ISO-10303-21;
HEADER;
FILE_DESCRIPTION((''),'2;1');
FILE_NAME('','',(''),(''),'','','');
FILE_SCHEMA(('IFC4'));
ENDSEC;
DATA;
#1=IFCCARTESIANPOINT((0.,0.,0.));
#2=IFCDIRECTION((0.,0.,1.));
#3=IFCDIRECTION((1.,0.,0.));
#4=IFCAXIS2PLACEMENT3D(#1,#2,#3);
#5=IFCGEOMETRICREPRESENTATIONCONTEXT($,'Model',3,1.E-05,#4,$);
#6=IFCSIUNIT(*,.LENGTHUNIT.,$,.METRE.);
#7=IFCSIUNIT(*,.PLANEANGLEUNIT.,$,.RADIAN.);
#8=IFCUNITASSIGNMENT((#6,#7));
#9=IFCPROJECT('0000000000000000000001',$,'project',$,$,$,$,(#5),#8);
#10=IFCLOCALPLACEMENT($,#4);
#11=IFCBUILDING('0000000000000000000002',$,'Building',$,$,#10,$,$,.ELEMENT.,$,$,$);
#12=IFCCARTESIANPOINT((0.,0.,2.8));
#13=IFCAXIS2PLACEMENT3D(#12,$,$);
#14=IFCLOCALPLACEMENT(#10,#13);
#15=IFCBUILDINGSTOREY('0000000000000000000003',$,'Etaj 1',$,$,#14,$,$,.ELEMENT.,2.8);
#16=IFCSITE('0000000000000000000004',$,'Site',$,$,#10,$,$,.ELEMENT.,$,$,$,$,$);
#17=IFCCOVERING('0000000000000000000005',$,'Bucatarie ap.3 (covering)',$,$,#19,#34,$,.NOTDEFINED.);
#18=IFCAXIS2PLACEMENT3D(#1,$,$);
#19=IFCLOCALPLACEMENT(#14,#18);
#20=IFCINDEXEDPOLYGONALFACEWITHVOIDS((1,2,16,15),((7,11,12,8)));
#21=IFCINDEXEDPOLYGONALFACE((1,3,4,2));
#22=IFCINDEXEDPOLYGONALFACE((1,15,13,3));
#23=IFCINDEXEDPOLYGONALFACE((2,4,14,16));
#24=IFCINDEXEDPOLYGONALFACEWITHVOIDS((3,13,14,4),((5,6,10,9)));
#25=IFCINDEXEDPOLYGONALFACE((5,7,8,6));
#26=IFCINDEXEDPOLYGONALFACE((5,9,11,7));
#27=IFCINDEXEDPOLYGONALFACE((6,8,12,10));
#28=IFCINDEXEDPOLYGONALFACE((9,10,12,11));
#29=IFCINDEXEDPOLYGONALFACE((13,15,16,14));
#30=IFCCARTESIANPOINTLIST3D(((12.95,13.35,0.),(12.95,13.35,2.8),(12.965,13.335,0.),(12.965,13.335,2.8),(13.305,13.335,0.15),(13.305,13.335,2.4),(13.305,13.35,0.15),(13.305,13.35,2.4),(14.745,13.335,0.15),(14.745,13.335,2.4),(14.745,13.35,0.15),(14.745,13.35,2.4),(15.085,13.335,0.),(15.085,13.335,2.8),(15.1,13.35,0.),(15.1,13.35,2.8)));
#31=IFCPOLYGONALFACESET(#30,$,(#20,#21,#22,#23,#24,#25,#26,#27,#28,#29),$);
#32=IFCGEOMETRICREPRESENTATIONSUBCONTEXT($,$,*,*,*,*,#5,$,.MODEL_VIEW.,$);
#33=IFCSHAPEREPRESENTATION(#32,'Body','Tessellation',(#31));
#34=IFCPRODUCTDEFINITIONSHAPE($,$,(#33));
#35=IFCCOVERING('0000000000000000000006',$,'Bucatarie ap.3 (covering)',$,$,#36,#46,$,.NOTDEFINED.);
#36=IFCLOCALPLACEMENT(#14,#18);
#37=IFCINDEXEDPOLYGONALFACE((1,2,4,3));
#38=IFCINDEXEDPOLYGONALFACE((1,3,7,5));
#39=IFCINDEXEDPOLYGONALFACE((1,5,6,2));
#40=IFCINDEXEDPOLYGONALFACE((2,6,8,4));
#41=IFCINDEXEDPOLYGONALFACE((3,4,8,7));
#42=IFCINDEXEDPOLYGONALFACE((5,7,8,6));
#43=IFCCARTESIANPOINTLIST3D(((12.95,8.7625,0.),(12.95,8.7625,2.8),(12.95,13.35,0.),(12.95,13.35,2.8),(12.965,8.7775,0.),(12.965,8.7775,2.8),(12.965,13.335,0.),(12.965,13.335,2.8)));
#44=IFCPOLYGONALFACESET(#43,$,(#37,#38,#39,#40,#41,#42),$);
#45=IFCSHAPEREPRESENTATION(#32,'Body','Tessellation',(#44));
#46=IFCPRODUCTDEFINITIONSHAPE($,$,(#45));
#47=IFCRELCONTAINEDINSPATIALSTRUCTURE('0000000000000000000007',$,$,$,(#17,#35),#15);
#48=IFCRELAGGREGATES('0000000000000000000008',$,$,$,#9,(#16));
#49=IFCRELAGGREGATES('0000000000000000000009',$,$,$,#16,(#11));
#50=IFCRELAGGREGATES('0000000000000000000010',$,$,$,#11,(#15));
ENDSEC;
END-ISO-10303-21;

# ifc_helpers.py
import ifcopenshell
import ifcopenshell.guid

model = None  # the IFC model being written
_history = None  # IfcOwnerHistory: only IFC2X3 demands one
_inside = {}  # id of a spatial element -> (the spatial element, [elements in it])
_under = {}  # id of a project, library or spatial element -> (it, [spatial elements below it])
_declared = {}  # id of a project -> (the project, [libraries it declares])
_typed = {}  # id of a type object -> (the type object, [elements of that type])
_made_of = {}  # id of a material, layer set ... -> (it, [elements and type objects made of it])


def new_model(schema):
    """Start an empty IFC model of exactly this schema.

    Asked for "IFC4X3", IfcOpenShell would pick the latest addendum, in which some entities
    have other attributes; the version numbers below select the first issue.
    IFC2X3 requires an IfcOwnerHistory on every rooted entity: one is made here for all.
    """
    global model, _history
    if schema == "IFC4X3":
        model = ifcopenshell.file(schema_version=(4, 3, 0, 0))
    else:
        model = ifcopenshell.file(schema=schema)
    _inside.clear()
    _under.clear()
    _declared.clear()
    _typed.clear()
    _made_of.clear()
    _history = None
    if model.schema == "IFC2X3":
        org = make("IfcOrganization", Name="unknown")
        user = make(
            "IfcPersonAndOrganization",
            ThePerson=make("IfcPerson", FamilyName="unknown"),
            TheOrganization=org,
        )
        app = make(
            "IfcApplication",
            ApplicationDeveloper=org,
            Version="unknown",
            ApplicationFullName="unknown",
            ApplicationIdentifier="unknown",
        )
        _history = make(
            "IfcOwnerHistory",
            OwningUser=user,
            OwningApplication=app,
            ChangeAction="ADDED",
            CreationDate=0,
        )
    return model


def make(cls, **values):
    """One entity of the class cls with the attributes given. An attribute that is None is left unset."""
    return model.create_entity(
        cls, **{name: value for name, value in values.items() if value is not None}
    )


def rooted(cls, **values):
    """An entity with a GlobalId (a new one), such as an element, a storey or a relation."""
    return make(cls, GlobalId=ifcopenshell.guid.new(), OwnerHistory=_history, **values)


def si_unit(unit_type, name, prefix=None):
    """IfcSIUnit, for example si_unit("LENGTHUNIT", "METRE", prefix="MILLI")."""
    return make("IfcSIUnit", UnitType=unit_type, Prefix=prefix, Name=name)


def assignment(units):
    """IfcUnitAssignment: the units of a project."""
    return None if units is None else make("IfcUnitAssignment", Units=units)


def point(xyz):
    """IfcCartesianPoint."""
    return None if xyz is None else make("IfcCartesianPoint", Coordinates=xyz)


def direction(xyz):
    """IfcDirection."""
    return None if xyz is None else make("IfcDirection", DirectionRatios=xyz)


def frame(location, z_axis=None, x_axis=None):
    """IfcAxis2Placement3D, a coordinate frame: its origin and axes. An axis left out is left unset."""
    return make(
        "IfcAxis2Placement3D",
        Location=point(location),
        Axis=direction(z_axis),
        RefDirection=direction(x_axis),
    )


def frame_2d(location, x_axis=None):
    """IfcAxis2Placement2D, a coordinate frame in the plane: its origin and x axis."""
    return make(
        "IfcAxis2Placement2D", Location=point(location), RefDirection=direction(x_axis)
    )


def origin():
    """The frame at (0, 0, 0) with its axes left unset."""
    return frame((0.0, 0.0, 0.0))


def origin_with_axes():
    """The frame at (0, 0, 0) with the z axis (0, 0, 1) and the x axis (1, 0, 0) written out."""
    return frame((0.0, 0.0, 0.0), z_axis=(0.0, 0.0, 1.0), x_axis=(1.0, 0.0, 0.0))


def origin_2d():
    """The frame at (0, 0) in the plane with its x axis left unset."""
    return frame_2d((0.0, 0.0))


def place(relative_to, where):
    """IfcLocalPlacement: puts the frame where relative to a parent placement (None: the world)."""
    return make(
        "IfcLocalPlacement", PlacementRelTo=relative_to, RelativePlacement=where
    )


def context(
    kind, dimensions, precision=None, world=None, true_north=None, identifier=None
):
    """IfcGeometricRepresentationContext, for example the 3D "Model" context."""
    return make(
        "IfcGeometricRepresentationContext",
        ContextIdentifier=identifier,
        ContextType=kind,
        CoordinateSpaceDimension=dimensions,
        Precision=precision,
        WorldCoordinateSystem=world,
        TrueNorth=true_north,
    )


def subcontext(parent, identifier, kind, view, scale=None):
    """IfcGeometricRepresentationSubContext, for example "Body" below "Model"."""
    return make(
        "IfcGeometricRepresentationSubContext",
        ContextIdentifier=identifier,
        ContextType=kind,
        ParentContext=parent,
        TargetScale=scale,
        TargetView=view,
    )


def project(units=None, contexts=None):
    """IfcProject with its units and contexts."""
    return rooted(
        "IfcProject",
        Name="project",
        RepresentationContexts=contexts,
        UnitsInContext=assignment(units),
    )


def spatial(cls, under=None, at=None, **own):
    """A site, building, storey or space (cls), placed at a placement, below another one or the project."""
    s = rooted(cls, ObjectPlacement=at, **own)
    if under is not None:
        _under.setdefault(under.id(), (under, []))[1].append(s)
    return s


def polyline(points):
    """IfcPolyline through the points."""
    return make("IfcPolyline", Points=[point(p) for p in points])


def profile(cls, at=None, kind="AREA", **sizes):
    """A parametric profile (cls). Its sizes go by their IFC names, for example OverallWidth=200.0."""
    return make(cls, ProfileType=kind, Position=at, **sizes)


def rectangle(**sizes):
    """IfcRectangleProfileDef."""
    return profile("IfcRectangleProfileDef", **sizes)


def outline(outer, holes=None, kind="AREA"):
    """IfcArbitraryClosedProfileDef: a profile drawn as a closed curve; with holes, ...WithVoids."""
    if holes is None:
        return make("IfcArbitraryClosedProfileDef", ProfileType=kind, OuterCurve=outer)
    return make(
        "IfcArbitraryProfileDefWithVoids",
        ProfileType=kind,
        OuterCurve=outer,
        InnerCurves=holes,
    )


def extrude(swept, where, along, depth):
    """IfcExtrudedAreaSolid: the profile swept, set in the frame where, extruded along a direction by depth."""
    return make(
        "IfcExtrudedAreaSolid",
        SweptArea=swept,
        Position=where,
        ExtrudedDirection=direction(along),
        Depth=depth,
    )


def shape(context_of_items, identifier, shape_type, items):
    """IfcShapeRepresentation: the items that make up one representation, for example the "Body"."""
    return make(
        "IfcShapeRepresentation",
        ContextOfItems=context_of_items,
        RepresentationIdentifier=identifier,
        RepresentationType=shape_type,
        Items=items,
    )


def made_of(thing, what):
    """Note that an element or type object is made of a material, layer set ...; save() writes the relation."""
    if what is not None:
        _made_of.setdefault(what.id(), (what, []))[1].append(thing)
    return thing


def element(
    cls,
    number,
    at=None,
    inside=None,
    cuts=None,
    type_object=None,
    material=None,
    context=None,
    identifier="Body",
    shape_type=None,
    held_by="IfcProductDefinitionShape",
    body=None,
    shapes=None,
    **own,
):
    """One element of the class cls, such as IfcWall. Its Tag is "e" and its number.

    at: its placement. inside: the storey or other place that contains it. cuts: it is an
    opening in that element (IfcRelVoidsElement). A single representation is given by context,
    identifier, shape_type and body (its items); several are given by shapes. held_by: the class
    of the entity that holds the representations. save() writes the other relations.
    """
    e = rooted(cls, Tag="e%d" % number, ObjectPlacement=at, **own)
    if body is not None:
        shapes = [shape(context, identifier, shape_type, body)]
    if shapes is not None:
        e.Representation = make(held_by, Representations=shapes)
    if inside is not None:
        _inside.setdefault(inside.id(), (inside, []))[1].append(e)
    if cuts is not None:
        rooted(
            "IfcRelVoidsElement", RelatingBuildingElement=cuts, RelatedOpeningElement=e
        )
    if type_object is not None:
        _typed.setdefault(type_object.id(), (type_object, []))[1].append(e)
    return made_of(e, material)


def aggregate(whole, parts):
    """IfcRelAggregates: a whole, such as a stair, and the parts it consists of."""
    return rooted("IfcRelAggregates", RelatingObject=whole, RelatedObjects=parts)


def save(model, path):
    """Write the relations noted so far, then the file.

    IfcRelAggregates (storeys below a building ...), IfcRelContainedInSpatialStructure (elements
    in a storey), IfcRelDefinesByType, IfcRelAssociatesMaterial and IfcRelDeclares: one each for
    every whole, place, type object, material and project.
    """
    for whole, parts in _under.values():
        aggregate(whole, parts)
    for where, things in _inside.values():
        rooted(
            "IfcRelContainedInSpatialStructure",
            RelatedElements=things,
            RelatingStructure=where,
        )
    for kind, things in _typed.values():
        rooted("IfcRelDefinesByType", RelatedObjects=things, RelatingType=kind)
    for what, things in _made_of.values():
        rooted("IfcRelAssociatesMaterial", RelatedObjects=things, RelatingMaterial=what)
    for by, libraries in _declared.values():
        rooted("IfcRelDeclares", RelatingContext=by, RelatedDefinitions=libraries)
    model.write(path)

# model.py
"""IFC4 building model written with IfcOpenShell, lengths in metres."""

from ifc_helpers import new_model, si_unit, frame, origin, origin_with_axes, origin_2d, place, context, subcontext, project, spatial, polyline, rectangle, outline, extrude, element, save


model = new_model("IFC4")

# Units and contexts
model_context = context("Model", 3, precision=1e-05, world=origin_with_axes())
sub_context = subcontext(model_context, None, None, "MODEL_VIEW")
ifc_project = project(units=[si_unit("LENGTHUNIT", "METRE"), si_unit("PLANEANGLEUNIT", "RADIAN")], contexts=[model_context])

# Site, building, storey
placement = place(None, origin_with_axes())
site = spatial("IfcSite", under=ifc_project, at=placement, Name="Site", CompositionType="ELEMENT")
building = spatial("IfcBuilding", under=site, at=placement, Name="Building", CompositionType="ELEMENT")
storey_placement = place(placement, frame((0.0, 0.0, 2.8)))
storey = spatial("IfcBuildingStorey", under=building, at=storey_placement, Name="Etaj 1", CompositionType="ELEMENT", Elevation=2.8)

# Covering, opening
covering_1_placement = place(storey_placement, origin_with_axes())
covering_1 = element("IfcCovering", 1, at=covering_1_placement, inside=storey, Name="Bucatarie ap.3 (covering)", PredefinedType="NOTDEFINED", context=sub_context, shape_type="SweptSolid", body=[
    extrude(outline(polyline([(15.1, 13.35), (12.95, 13.35), (12.965, 13.335), (15.085, 13.335), (15.1, 13.35)])), origin(), (0.0, 0.0, 1.0), 2.8),
])
opening_1_placement = place(covering_1_placement, frame((14.025, 13.665, 0.15), z_axis=(0.0, -1.0, 0.0), x_axis=(1.0, 0.0, 0.0)))
element("IfcOpeningElement", 2, at=opening_1_placement, cuts=covering_1, PredefinedType="OPENING", context=sub_context, shape_type="SweptSolid", body=[
    extrude(rectangle(XDim=1.44, YDim=2.25, at=origin_2d()), frame((0.0, 1.125, 0.0)), (0.0, 0.0, 1.0), 0.38),
])

# Covering
covering_2_placement = place(storey_placement, origin_with_axes())
element("IfcCovering", 3, at=covering_2_placement, inside=storey, Name="Bucatarie ap.3 (covering)", PredefinedType="NOTDEFINED", context=sub_context, shape_type="SweptSolid", body=[
    extrude(outline(polyline([(12.95, 13.35), (12.95, 8.7625), (12.965, 8.7775), (12.965, 13.335), (12.95, 13.35)])), origin(), (0.0, 0.0, 1.0), 2.8),
])

save(model, "model.ifc")
